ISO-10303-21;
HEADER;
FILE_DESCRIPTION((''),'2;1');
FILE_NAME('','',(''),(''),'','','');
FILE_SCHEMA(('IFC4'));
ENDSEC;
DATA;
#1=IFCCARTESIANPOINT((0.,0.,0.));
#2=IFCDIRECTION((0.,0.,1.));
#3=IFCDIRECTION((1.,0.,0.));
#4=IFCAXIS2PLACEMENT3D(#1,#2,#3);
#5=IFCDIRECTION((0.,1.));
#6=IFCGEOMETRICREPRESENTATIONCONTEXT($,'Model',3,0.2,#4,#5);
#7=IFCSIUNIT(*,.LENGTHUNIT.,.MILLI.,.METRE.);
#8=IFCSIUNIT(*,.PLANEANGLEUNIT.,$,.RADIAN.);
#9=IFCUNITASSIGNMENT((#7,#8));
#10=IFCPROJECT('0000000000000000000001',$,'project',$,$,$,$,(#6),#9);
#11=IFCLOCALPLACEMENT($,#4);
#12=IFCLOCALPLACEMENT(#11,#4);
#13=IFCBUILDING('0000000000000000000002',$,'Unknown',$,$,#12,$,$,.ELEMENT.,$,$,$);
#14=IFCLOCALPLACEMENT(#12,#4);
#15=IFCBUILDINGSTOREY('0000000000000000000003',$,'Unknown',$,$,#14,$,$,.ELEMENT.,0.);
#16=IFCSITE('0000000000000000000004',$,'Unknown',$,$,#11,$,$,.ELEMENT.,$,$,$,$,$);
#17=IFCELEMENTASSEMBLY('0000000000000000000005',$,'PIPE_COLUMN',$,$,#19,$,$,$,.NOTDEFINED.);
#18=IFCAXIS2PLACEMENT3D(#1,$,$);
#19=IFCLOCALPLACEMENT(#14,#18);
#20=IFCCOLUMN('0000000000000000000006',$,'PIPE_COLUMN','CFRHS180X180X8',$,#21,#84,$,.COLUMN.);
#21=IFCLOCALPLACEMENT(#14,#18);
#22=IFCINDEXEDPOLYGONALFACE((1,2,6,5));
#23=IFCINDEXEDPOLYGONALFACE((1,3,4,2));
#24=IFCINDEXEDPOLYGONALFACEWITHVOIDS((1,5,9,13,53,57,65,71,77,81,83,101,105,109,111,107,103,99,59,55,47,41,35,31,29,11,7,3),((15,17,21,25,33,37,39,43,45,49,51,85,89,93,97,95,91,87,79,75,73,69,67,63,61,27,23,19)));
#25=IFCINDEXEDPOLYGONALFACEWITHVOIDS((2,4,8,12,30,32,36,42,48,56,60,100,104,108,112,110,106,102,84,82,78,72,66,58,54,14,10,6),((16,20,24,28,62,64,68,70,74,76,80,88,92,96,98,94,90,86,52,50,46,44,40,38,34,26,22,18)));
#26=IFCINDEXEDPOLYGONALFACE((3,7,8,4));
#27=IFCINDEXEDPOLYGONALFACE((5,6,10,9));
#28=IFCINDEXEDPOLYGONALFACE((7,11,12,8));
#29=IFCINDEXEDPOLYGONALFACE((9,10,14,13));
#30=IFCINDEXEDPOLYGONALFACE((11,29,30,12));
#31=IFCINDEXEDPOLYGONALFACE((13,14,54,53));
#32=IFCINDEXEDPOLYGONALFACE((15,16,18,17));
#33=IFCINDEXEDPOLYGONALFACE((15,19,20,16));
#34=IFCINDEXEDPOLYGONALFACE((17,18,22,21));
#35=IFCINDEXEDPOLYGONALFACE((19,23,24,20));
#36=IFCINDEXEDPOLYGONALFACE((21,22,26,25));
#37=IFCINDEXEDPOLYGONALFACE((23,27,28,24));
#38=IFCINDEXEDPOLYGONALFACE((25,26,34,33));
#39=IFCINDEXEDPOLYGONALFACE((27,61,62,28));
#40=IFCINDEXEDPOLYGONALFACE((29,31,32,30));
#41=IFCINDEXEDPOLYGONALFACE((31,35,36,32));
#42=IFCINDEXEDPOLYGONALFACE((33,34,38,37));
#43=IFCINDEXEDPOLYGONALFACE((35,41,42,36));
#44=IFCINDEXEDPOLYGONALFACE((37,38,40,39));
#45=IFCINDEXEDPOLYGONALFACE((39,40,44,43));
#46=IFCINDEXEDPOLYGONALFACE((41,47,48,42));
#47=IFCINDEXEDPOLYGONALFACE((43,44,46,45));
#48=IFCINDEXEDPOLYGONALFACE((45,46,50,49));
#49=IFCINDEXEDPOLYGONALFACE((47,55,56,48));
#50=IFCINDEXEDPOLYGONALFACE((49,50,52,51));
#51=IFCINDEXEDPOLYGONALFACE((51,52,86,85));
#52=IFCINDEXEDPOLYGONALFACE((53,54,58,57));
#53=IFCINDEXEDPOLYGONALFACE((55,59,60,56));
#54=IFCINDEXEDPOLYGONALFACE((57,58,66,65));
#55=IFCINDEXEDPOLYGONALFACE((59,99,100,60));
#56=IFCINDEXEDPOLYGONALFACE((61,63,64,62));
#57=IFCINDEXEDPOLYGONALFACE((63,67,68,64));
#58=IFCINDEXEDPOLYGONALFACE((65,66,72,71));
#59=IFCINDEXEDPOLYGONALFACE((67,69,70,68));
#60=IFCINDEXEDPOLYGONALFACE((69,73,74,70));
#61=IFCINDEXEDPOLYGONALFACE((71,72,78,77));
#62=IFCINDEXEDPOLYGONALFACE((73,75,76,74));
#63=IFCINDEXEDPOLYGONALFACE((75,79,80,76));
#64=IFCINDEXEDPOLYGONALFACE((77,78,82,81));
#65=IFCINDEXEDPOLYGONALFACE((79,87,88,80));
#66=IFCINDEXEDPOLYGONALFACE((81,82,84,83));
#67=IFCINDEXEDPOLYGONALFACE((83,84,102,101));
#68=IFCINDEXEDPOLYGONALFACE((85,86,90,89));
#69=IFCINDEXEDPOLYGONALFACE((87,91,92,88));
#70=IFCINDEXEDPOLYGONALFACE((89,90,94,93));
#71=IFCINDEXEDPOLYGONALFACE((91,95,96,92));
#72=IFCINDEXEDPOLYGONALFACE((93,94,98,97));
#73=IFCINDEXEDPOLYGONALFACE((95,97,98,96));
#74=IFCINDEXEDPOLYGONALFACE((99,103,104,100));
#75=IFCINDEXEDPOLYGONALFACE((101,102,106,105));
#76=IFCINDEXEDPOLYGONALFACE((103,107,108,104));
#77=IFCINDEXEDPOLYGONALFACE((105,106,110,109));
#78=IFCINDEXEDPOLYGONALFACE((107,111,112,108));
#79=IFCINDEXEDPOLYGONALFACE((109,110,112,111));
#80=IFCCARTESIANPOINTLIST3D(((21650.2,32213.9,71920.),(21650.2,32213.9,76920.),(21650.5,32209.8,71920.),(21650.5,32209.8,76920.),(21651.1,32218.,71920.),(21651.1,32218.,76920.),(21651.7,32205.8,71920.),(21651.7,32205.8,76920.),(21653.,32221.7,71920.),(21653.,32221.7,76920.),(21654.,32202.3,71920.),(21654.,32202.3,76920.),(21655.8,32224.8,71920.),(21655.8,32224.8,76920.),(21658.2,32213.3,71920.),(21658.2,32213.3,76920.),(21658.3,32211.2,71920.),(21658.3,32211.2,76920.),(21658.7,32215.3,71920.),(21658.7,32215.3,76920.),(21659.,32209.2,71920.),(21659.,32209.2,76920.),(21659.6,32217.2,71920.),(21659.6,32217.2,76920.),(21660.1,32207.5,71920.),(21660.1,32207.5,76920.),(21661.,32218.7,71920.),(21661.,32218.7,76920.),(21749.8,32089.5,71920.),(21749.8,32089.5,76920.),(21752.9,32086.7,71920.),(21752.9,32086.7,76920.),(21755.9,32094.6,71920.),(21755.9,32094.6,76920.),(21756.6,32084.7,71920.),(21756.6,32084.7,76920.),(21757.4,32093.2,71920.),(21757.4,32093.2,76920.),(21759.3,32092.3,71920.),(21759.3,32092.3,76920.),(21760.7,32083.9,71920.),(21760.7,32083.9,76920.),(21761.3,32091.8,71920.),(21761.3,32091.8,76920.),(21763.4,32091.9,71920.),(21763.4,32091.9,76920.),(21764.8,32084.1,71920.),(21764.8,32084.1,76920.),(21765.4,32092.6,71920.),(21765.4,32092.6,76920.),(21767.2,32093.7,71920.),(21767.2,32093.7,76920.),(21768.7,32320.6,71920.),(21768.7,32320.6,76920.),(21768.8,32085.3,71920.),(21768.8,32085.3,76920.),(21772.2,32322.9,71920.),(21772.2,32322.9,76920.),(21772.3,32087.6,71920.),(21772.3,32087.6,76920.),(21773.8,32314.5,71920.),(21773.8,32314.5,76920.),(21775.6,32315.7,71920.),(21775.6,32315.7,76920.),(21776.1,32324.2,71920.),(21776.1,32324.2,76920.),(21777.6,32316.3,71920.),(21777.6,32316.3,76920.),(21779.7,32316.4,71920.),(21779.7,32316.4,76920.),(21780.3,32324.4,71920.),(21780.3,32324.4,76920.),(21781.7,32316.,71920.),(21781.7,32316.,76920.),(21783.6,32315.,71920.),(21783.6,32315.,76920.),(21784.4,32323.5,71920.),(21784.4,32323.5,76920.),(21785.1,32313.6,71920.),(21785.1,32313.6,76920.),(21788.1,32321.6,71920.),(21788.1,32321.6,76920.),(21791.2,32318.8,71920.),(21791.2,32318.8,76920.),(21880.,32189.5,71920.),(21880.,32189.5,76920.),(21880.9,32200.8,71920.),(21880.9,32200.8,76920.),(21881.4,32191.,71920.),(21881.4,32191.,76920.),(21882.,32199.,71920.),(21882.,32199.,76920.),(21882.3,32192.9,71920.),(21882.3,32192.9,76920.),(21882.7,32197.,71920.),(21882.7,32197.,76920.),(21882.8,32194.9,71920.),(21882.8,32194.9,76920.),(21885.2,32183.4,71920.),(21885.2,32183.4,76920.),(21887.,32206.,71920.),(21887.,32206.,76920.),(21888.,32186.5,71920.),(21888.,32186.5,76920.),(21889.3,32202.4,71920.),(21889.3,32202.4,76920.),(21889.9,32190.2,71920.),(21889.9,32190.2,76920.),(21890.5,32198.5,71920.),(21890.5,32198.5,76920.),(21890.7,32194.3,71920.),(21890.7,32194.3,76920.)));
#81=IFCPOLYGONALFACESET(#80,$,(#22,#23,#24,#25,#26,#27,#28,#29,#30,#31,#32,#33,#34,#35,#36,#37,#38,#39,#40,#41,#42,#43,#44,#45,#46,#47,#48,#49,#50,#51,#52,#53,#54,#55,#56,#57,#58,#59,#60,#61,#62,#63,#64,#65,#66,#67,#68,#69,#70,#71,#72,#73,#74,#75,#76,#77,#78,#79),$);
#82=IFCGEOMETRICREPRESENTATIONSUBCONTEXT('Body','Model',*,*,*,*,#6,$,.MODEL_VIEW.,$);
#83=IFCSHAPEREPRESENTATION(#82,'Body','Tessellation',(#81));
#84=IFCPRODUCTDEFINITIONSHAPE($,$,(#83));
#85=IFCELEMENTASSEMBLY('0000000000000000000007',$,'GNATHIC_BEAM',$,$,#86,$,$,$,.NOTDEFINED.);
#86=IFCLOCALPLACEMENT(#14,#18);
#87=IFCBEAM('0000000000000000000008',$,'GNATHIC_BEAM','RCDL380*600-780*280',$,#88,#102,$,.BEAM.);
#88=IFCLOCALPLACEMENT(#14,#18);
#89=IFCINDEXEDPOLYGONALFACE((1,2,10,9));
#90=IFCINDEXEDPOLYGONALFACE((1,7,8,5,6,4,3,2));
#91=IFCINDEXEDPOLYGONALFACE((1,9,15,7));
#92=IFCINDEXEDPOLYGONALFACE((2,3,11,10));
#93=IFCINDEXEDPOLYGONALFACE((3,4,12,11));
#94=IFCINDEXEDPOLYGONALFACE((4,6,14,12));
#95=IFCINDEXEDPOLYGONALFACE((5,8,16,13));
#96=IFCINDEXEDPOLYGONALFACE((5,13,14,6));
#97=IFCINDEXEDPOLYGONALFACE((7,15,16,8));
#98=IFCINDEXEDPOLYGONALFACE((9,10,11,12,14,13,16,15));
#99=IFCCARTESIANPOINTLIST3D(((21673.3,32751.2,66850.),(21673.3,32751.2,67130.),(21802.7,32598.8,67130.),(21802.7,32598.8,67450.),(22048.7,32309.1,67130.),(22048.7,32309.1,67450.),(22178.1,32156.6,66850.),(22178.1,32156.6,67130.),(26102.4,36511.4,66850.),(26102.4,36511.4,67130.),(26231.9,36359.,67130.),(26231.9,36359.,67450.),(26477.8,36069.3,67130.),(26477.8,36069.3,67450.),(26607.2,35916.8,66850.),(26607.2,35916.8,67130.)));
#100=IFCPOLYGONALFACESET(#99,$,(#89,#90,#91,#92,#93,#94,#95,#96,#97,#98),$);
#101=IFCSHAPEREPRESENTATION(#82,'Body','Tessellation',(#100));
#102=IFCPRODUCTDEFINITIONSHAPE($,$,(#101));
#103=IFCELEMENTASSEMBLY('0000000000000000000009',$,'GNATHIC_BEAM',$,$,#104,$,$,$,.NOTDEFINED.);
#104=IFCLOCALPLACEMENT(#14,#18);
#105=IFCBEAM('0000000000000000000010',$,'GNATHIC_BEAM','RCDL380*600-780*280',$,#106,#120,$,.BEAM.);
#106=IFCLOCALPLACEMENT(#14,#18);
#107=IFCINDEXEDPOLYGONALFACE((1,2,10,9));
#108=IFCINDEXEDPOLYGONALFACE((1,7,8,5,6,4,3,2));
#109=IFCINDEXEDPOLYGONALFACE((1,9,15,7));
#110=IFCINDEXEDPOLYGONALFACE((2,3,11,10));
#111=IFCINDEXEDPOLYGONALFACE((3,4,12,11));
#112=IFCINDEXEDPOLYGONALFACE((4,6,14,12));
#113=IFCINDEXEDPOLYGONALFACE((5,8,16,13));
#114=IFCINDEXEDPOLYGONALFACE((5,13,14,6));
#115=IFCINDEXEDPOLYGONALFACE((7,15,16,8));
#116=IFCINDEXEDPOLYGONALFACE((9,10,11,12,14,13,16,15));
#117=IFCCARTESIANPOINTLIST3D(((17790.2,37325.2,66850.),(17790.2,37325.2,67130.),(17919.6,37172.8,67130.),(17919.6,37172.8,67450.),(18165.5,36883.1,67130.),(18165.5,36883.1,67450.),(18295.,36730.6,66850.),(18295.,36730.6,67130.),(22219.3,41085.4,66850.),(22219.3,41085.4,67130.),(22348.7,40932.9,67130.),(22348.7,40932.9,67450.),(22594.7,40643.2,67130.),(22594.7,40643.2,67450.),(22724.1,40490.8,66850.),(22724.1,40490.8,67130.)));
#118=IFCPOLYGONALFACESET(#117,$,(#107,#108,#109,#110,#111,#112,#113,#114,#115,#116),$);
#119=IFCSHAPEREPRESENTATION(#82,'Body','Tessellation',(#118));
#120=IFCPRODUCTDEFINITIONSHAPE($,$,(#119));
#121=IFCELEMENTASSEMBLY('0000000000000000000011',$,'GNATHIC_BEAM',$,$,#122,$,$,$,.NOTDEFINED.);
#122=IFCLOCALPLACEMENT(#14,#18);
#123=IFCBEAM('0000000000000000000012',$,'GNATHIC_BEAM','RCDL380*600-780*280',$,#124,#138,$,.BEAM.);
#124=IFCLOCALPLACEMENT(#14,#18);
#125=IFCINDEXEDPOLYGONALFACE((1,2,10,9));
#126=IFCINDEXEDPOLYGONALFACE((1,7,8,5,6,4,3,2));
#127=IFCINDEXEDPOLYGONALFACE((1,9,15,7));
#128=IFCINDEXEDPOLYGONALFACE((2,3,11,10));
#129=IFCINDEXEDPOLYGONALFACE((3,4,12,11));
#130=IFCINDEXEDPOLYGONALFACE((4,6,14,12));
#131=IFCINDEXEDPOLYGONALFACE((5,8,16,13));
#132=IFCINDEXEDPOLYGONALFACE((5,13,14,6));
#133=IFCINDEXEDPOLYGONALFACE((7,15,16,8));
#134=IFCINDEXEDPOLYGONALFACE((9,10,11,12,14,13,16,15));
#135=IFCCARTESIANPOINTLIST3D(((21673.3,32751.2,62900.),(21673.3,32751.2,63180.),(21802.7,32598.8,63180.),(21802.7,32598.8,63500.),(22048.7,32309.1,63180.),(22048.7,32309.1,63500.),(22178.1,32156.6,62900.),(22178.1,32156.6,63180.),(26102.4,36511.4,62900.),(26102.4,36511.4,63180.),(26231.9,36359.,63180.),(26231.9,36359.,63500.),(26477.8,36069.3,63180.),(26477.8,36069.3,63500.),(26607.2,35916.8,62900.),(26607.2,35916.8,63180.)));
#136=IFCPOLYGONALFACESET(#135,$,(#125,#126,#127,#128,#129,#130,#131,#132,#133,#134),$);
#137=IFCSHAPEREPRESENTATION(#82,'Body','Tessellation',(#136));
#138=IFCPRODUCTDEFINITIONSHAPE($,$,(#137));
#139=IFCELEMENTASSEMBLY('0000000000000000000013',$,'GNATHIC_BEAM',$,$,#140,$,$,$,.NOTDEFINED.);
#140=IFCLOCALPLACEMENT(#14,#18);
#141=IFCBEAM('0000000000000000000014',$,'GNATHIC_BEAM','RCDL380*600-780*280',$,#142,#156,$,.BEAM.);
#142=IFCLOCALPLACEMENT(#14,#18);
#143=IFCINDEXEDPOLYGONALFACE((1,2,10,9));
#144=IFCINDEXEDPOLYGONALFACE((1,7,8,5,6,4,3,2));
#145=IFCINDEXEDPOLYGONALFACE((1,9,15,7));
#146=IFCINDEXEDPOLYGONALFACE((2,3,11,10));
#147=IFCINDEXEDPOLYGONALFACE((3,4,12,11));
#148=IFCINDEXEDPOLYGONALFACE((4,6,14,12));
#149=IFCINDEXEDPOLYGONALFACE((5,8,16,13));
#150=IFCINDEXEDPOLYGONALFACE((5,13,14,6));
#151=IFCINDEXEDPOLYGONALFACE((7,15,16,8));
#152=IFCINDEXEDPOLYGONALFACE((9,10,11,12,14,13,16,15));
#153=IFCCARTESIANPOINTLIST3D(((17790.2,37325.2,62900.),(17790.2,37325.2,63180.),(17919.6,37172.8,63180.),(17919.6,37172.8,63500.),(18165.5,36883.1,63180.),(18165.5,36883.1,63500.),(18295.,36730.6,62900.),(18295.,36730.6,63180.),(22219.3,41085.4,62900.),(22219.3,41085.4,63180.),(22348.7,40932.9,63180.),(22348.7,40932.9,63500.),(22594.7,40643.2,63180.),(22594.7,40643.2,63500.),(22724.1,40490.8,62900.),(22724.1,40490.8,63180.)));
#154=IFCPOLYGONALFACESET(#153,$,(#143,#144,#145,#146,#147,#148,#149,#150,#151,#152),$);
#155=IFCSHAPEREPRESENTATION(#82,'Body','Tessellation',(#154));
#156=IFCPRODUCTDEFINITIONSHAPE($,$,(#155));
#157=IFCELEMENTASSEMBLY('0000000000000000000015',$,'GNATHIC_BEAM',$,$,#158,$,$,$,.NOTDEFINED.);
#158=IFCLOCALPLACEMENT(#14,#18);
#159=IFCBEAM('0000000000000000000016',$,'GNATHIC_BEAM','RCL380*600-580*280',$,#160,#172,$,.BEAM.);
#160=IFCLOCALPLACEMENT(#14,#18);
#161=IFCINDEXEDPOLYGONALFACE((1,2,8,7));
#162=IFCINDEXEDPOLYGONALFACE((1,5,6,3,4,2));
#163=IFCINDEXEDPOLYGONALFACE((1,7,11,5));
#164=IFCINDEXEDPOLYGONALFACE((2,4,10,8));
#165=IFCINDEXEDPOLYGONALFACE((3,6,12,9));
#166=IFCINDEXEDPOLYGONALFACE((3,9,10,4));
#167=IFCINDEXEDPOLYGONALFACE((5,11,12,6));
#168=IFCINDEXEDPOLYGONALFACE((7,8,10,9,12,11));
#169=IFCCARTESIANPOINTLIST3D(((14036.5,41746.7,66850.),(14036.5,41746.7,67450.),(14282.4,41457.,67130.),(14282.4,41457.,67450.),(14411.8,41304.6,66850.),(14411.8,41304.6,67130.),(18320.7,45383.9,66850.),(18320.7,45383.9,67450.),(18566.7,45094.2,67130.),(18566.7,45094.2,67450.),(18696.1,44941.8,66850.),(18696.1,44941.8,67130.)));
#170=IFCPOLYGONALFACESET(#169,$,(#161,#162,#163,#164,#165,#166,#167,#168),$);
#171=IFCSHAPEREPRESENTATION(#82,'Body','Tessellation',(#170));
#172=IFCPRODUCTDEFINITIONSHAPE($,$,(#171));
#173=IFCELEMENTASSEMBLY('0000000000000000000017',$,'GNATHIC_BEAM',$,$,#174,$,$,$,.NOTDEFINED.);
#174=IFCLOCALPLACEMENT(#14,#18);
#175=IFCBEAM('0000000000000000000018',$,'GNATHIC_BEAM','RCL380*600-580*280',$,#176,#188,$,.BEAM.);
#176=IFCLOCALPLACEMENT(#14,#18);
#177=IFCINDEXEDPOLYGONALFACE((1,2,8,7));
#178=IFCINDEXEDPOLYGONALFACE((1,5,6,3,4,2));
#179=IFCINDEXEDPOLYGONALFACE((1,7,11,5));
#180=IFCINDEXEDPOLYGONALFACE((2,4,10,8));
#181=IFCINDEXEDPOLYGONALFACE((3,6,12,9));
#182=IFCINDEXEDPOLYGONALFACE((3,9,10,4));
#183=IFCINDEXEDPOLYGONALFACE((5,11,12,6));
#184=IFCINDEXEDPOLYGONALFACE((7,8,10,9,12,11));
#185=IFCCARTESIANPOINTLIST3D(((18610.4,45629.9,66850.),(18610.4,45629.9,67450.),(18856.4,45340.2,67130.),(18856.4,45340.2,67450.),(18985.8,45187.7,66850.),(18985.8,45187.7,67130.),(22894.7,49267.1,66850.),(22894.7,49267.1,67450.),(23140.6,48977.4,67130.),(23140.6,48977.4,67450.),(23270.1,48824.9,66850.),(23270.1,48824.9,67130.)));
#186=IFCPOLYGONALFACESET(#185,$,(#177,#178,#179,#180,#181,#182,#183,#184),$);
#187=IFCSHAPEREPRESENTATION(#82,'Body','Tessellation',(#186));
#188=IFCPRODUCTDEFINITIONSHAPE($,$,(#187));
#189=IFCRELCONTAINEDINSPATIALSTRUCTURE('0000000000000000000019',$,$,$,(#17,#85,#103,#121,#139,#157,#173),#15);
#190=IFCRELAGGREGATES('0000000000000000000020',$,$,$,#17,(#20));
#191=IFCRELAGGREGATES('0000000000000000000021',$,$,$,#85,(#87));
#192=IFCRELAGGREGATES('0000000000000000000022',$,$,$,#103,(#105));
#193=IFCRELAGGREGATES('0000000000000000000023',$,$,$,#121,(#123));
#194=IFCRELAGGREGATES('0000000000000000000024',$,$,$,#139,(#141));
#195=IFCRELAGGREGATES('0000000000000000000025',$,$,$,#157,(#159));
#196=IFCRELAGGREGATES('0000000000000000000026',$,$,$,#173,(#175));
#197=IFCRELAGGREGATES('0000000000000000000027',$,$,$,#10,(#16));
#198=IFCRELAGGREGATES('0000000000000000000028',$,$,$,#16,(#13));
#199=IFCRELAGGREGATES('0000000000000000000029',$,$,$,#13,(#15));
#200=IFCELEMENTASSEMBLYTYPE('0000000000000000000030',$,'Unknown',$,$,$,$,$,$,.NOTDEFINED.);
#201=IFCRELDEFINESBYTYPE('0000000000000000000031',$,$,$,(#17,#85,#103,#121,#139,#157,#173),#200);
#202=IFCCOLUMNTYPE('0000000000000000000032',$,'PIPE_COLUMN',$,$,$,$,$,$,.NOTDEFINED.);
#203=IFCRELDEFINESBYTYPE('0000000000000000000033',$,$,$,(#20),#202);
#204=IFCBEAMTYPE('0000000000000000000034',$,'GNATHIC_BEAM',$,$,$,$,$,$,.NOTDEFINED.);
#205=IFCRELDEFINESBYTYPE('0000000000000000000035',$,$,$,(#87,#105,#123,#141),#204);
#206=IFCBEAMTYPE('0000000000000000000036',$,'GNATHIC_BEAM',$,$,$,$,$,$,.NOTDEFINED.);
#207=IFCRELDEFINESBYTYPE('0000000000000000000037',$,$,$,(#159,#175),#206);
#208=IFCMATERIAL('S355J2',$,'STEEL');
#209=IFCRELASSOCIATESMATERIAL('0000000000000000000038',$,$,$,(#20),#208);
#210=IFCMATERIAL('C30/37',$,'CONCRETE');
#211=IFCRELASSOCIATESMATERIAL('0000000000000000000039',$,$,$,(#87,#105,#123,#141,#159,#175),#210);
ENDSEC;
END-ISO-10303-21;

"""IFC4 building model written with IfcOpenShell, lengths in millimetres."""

from ifc_helpers import new_model, si_unit, direction, frame, origin_with_axes, origin_2d_with_axis, place, context, subcontext, project, spatial, polyline, hollow_rectangle, outline, extrude, material, material_profile, profile_set, profile_usage, type_object, element, aggregate, save


model = new_model("IFC4")

# Units and contexts
model_context = context("Model", 3, precision=0.2, world=origin_with_axes(), true_north=direction((0.0, 1.0)))
body_context = subcontext(model_context, "Body", "Model", "MODEL_VIEW")
ifc_project = project(units=[si_unit("LENGTHUNIT", "METRE", prefix="MILLI"), si_unit("PLANEANGLEUNIT", "RADIAN")], contexts=[model_context])

# Site, building, storey
site_placement = place(None, origin_with_axes())
site = spatial("IfcSite", under=ifc_project, at=site_placement, Name="Unknown", CompositionType="ELEMENT")
building_placement = place(site_placement, origin_with_axes())
building = spatial("IfcBuilding", under=site, at=building_placement, Name="Unknown", CompositionType="ELEMENT")
storey_placement = place(building_placement, origin_with_axes())
storey = spatial("IfcBuildingStorey", under=building, at=storey_placement, Name="Unknown", CompositionType="ELEMENT", Elevation=0.0)

# Element assembly, column
element_assembly_type = type_object("IfcElementAssemblyType", Name="Unknown", PredefinedType="NOTDEFINED")
ifc_material_1 = material(Name="S355J2", Category="STEEL")
ifc_material_profile_1 = material_profile(ifc_material_1, hollow_rectangle(XDim=180.0, YDim=180.0, WallThickness=8.0, InnerFilletRadius=8.0, OuterFilletRadius=16.0, at=origin_2d_with_axis()), Name="CFRHS180X180X8")
ifc_profile_set_1 = profile_set([ifc_material_profile_1])
column_type_1 = type_object("IfcColumnType", Name="PIPE_COLUMN")
assembly_1_placement = place(storey_placement, frame((21770.5, 32204.1, 71920.0), z_axis=(-0.762329, -0.64719, 0.0), x_axis=(0.0, 0.0, 1.0)))
assembly_1 = element("IfcElementAssembly", 1, at=assembly_1_placement, inside=storey, type_object=element_assembly_type, Name="PIPE_COLUMN", PredefinedType="NOTDEFINED")
ifc_profile_usage_1 = profile_usage(ifc_profile_set_1, cardinal=1)
column_1_placement = place(assembly_1_placement, origin_with_axes())
column_1 = element("IfcColumn", 2, at=column_1_placement, type_object=column_type_1, material=ifc_profile_usage_1, Name="PIPE_COLUMN", Description="CFRHS180X180X8", PredefinedType="COLUMN", context=body_context, shape_type="SolidModel", body=[
    extrude(hollow_rectangle(XDim=180.0, YDim=180.0, WallThickness=8.0, InnerFilletRadius=8.0, OuterFilletRadius=16.0, at=origin_2d_with_axis()), frame((0.0, 0.0, 0.0), z_axis=(-1.0, 0.0, 0.0), x_axis=(0.0, 0.0, 1.0)), (0.0, 0.0, -1.0), 5000.0),
])
aggregate(assembly_1, [column_1])

# Element assemblies, beams
assembly_2_placement = place(storey_placement, frame((21925.7, 32453.9, 67150.0), z_axis=(0.64719, -0.762329, 0.0), x_axis=(0.762329, 0.64719, 0.0)))
assembly_2 = element("IfcElementAssembly", 3, at=assembly_2_placement, inside=storey, type_object=element_assembly_type, Name="GNATHIC_BEAM", PredefinedType="NOTDEFINED")
ifc_material_2 = material(Name="C30/37", Category="CONCRETE")
ifc_material_profile_2 = material_profile(ifc_material_2, outline(polyline([(-390.0, -300.0), (390.0, -300.0), (390.0, -20.0), (190.0, -20.0), (190.0, 300.0), (-190.0, 300.0), (-190.0, -20.0), (-390.0, -20.0), (-390.0, -300.0)])), Name="RCDL380*600-780*280")
ifc_profile_set_2 = profile_set([ifc_material_profile_2])
ifc_profile_usage_2 = profile_usage(ifc_profile_set_2, cardinal=2)
beam_type_1 = type_object("IfcBeamType", Name="GNATHIC_BEAM")
beam_1_placement = place(assembly_2_placement, origin_with_axes())
beam_1 = element("IfcBeam", 4, at=beam_1_placement, type_object=beam_type_1, material=ifc_profile_usage_2, Name="GNATHIC_BEAM", Description="RCDL380*600-780*280", PredefinedType="BEAM", context=body_context, shape_type="SolidModel", body=[
    extrude(outline(polyline([(-390.0, -300.0), (390.0, -300.0), (390.0, -20.0), (190.0, -20.0), (190.0, 300.0), (-190.0, 300.0), (-190.0, -20.0), (-390.0, -20.0), (-390.0, -300.0)])), frame((0.0, 0.0, 0.0), z_axis=(-1.0, 0.0, 0.0), x_axis=(0.0, 0.0, 1.0)), (0.0, 0.0, -1.0), 5810.0),
])
aggregate(assembly_2, [beam_1])
assembly_3_placement = place(storey_placement, frame((18042.6, 37027.9, 67150.0), z_axis=(0.64719, -0.762329, 0.0), x_axis=(0.762329, 0.64719, 0.0)))
assembly_3 = element("IfcElementAssembly", 5, at=assembly_3_placement, inside=storey, type_object=element_assembly_type, Name="GNATHIC_BEAM", PredefinedType="NOTDEFINED")
beam_2_placement = place(assembly_3_placement, origin_with_axes())
beam_2 = element("IfcBeam", 6, at=beam_2_placement, type_object=beam_type_1, material=ifc_profile_usage_2, Name="GNATHIC_BEAM", Description="RCDL380*600-780*280", PredefinedType="BEAM", context=body_context, shape_type="SolidModel", body=[
    extrude(outline(polyline([(-390.0, -300.0), (390.0, -300.0), (390.0, -20.0), (190.0, -20.0), (190.0, 300.0), (-190.0, 300.0), (-190.0, -20.0), (-390.0, -20.0), (-390.0, -300.0)])), frame((0.0, 0.0, 0.0), z_axis=(-1.0, 0.0, 0.0), x_axis=(0.0, 0.0, 1.0)), (0.0, 0.0, -1.0), 5810.0),
])
aggregate(assembly_3, [beam_2])
assembly_4_placement = place(storey_placement, frame((21925.7, 32453.9, 63200.0), z_axis=(0.64719, -0.762329, 0.0), x_axis=(0.762329, 0.64719, 0.0)))
assembly_4 = element("IfcElementAssembly", 7, at=assembly_4_placement, inside=storey, type_object=element_assembly_type, Name="GNATHIC_BEAM", PredefinedType="NOTDEFINED")
beam_3_placement = place(assembly_4_placement, origin_with_axes())
beam_3 = element("IfcBeam", 8, at=beam_3_placement, type_object=beam_type_1, material=ifc_profile_usage_2, Name="GNATHIC_BEAM", Description="RCDL380*600-780*280", PredefinedType="BEAM", context=body_context, shape_type="SolidModel", body=[
    extrude(outline(polyline([(-390.0, -300.0), (390.0, -300.0), (390.0, -20.0), (190.0, -20.0), (190.0, 300.0), (-190.0, 300.0), (-190.0, -20.0), (-390.0, -20.0), (-390.0, -300.0)])), frame((0.0, 0.0, 0.0), z_axis=(-1.0, 0.0, 0.0), x_axis=(0.0, 0.0, 1.0)), (0.0, 0.0, -1.0), 5810.0),
])
aggregate(assembly_4, [beam_3])
assembly_5_placement = place(storey_placement, frame((18042.6, 37027.9, 63200.0), z_axis=(0.64719, -0.762329, 0.0), x_axis=(0.762329, 0.64719, 0.0)))
assembly_5 = element("IfcElementAssembly", 9, at=assembly_5_placement, inside=storey, type_object=element_assembly_type, Name="GNATHIC_BEAM", PredefinedType="NOTDEFINED")
beam_4_placement = place(assembly_5_placement, origin_with_axes())
beam_4 = element("IfcBeam", 10, at=beam_4_placement, type_object=beam_type_1, material=ifc_profile_usage_2, Name="GNATHIC_BEAM", Description="RCDL380*600-780*280", PredefinedType="BEAM", context=body_context, shape_type="SolidModel", body=[
    extrude(outline(polyline([(-390.0, -300.0), (390.0, -300.0), (390.0, -20.0), (190.0, -20.0), (190.0, 300.0), (-190.0, 300.0), (-190.0, -20.0), (-390.0, -20.0), (-390.0, -300.0)])), frame((0.0, 0.0, 0.0), z_axis=(-1.0, 0.0, 0.0), x_axis=(0.0, 0.0, 1.0)), (0.0, 0.0, -1.0), 5810.0),
])
aggregate(assembly_5, [beam_4])
assembly_6_placement = place(storey_placement, frame((14159.4, 41601.9, 67150.0), z_axis=(0.64719, -0.762329, 0.0), x_axis=(0.762329, 0.64719, 0.0)))
assembly_6 = element("IfcElementAssembly", 11, at=assembly_6_placement, inside=storey, type_object=element_assembly_type, Name="GNATHIC_BEAM", PredefinedType="NOTDEFINED")
ifc_material_profile_3 = material_profile(ifc_material_2, outline(polyline([(-190.0, -300.0), (390.0, -300.0), (390.0, -20.0), (190.0, -20.0), (190.0, 300.0), (-190.0, 300.0), (-190.0, -300.0)])), Name="RCL380*600-580*280")
ifc_profile_set_3 = profile_set([ifc_material_profile_3])
ifc_profile_usage_3 = profile_usage(ifc_profile_set_3, cardinal=2)
beam_type_2 = type_object("IfcBeamType", Name="GNATHIC_BEAM")
beam_5_placement = place(assembly_6_placement, origin_with_axes())
beam_5 = element("IfcBeam", 12, at=beam_5_placement, type_object=beam_type_2, material=ifc_profile_usage_3, Name="GNATHIC_BEAM", Description="RCL380*600-580*280", PredefinedType="BEAM", context=body_context, shape_type="SolidModel", body=[
    extrude(outline(polyline([(-190.0, -300.0), (390.0, -300.0), (390.0, -20.0), (190.0, -20.0), (190.0, 300.0), (-190.0, 300.0), (-190.0, -300.0)])), frame((0.0, 0.0, 0.0), z_axis=(-1.0, 0.0, 0.0), x_axis=(0.0, 0.0, 1.0)), (0.0, 0.0, -1.0), 5620.0),
])
aggregate(assembly_6, [beam_5])
assembly_7_placement = place(storey_placement, frame((18733.4, 45485.0, 67150.0), z_axis=(0.64719, -0.762329, 0.0), x_axis=(0.762329, 0.64719, 0.0)))
assembly_7 = element("IfcElementAssembly", 13, at=assembly_7_placement, inside=storey, type_object=element_assembly_type, Name="GNATHIC_BEAM", PredefinedType="NOTDEFINED")
beam_6_placement = place(assembly_7_placement, origin_with_axes())
beam_6 = element("IfcBeam", 14, at=beam_6_placement, type_object=beam_type_2, material=ifc_profile_usage_3, Name="GNATHIC_BEAM", Description="RCL380*600-580*280", PredefinedType="BEAM", context=body_context, shape_type="SolidModel", body=[
    extrude(outline(polyline([(-190.0, -300.0), (390.0, -300.0), (390.0, -20.0), (190.0, -20.0), (190.0, 300.0), (-190.0, 300.0), (-190.0, -300.0)])), frame((0.0, 0.0, 0.0), z_axis=(-1.0, 0.0, 0.0), x_axis=(0.0, 0.0, 1.0)), (0.0, 0.0, -1.0), 5620.0),
])
aggregate(assembly_7, [beam_6])

save(model, "model.ifc")
